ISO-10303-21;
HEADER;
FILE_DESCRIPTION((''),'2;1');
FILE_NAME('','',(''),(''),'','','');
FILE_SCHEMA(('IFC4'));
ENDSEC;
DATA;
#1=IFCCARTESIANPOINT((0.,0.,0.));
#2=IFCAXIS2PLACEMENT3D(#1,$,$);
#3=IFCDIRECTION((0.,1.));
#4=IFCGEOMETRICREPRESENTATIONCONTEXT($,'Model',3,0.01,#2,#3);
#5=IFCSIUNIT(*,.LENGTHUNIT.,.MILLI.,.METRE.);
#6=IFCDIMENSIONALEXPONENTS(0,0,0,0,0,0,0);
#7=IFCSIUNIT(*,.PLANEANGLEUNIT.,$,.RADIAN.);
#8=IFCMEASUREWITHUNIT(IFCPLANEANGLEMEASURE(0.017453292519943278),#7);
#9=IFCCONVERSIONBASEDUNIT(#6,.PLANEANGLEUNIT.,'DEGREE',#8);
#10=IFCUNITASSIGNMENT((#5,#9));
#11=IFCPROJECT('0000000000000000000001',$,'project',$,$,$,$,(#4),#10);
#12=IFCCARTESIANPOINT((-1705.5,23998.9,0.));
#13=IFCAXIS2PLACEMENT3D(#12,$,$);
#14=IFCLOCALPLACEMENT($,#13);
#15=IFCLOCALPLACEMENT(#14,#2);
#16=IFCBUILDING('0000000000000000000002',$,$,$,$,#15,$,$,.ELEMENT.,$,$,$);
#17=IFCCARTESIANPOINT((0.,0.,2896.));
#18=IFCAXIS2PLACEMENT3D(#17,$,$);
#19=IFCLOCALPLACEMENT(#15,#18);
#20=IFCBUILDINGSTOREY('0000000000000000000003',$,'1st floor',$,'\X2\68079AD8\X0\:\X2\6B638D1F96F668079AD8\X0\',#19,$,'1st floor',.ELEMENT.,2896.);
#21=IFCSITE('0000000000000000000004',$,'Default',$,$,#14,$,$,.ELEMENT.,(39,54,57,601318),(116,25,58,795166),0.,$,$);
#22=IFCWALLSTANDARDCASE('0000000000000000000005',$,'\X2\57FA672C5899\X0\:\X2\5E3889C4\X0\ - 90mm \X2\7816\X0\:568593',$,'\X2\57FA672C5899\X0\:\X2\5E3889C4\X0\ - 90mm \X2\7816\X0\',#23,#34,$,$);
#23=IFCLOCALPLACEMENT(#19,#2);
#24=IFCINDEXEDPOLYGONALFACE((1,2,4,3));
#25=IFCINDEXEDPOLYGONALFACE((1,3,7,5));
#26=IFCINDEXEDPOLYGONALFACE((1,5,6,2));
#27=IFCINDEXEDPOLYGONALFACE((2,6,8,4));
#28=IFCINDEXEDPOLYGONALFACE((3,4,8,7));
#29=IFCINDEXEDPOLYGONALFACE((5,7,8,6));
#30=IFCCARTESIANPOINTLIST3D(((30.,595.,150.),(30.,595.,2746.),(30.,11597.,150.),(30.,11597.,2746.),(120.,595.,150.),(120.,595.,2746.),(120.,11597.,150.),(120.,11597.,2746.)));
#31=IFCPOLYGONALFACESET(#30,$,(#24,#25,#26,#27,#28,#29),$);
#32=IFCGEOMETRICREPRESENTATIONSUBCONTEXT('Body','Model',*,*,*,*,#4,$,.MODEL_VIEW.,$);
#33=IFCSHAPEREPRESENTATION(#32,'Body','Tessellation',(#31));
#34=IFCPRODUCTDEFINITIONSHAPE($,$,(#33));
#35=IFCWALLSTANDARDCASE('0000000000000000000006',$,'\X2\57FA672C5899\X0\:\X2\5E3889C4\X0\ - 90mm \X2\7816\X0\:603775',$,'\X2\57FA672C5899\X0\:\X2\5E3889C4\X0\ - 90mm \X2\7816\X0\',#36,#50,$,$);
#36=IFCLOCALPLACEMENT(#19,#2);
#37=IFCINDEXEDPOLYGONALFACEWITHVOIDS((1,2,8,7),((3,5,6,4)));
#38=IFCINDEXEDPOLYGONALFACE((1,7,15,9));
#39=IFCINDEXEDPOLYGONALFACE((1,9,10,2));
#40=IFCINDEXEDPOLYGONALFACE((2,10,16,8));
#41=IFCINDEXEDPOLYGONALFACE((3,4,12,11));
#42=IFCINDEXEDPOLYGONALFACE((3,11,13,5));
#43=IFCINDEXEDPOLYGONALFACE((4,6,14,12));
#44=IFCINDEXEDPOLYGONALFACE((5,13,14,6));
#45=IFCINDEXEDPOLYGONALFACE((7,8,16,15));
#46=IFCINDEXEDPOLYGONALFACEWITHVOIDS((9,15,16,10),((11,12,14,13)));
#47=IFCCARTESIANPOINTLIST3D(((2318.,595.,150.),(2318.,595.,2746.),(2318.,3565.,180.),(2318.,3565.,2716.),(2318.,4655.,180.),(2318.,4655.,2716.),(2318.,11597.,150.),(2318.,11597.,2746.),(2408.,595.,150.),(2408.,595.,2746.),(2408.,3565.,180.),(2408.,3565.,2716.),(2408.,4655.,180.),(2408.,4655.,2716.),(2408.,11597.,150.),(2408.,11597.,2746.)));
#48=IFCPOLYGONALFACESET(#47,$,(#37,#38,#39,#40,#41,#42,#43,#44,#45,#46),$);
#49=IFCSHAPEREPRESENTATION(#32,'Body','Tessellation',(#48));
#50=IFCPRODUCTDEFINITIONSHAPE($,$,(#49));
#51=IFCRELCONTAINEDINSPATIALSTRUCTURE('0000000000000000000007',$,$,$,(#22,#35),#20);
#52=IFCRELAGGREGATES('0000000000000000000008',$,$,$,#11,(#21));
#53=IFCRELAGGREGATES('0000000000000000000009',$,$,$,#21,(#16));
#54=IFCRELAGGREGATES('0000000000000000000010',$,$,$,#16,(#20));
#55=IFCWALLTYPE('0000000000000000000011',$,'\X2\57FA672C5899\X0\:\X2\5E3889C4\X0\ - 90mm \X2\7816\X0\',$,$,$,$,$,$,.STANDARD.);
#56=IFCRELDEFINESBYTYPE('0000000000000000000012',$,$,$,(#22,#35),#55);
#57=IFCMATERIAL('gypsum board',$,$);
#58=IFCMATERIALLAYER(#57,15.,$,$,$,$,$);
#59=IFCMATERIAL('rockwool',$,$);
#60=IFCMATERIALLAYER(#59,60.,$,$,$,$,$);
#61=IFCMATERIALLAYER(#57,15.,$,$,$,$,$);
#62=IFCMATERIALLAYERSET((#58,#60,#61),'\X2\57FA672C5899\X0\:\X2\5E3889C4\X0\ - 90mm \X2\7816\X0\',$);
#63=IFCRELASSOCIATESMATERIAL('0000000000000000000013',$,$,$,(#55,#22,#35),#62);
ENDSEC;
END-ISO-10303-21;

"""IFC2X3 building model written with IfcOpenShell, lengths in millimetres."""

from ifc_helpers import new_model, entity, si_unit, converted_unit, direction, frame, frame_2d, origin, place, context, subcontext, project, spatial, rectangle, extrude, material, layer, layer_set, layer_usage, type_object, element, save


model = new_model("IFC2X3")

# Units and contexts
model_context = context("Model", 3, precision=0.01, world=origin(), true_north=direction((0.0, 1.0)))
body_context = subcontext(model_context, "Body", "Model", "MODEL_VIEW")
ifc_project = project(units=[si_unit("LENGTHUNIT", "METRE", prefix="MILLI"), converted_unit("PLANEANGLEUNIT", "DEGREE", entity("IfcPlaneAngleMeasure", 0.017453292519943278), si_unit("PLANEANGLEUNIT", "RADIAN"), dimensions=[0, 0, 0, 0, 0, 0, 0])], contexts=[model_context])

# Site, building, storey
site_placement = place(None, frame((-1705.5, 23998.9, 0.0)))
site = spatial("IfcSite", under=ifc_project, at=site_placement, Name="Default", CompositionType="ELEMENT", RefLatitude=(39, 54, 57, 601318), RefLongitude=(116, 25, 58, 795166), RefElevation=0.0)
building_placement = place(site_placement, origin())
building = spatial("IfcBuilding", under=site, at=building_placement, CompositionType="ELEMENT")
storey_placement = place(building_placement, frame((0.0, 0.0, 2896.0)))
storey = spatial("IfcBuildingStorey", under=building, at=storey_placement, Name="1st floor", ObjectType="标高:正负零标高", LongName="1st floor", CompositionType="ELEMENT", Elevation=2896.0)

# Wall
ifc_material_1 = material(Name="gypsum board")
ifc_layer_1 = layer(ifc_material_1, 15.0)
ifc_material_2 = material(Name="rockwool")
ifc_layer_2 = layer(ifc_material_2, 60.0)
ifc_layer_3 = layer(ifc_material_1, 15.0)
ifc_layer_set = layer_set([ifc_layer_1, ifc_layer_2, ifc_layer_3], Name="基本墙:常规 - 90mm 砖")
ifc_layer_usage_1 = layer_usage(ifc_layer_set, "AXIS2", "NEGATIVE", 45.0)
wall_type = type_object("IfcWallType", Name="基本墙:常规 - 90mm 砖", PredefinedType="STANDARD", material=ifc_layer_set)
wall_1_placement = place(storey_placement, frame((75.0, 11597.0, 150.0), z_axis=(0.0, 0.0, 1.0), x_axis=(0.0, -1.0, 0.0)))
element("IfcWallStandardCase", 1, at=wall_1_placement, inside=storey, type_object=wall_type, material=ifc_layer_usage_1, Name="基本墙:常规 - 90mm 砖:568593", ObjectType="基本墙:常规 - 90mm 砖", context=body_context, shape_type="SweptSolid", body=[
    extrude(rectangle(XDim=11002.0, YDim=90.0, at=frame_2d((5501.0, 0.0), x_axis=(-1.0, 0.0))), origin(), (0.0, 0.0, 1.0), 2596.0),
])

# Wall, opening
ifc_layer_usage_2 = layer_usage(ifc_layer_set, "AXIS2", "NEGATIVE", 45.0)
wall_2_placement = place(storey_placement, frame((2363.0, 11597.0, 150.0), z_axis=(0.0, 0.0, 1.0), x_axis=(0.0, -1.0, 0.0)))
wall_2 = element("IfcWallStandardCase", 2, at=wall_2_placement, inside=storey, type_object=wall_type, material=ifc_layer_usage_2, Name="基本墙:常规 - 90mm 砖:603775", ObjectType="基本墙:常规 - 90mm 砖", context=body_context, shape_type="SweptSolid", body=[
    extrude(rectangle(XDim=11002.0, YDim=90.0, at=frame_2d((5501.0, 0.0), x_axis=(-1.0, 0.0))), origin(), (0.0, 0.0, 1.0), 2596.0),
])
opening_1_placement = place(wall_2_placement, origin())
element("IfcOpeningElement", 3, at=opening_1_placement, cuts=wall_2, ObjectType="Opening", context=body_context, shape_type="SweptSolid", body=[
    extrude(rectangle(XDim=2536.0, YDim=1090.0, at=frame_2d((0.0, 0.0), x_axis=(0.0, 1.0))), frame((7487.0, 45.0, 1298.0), z_axis=(0.0, -1.0, 0.0), x_axis=(-1.0, 0.0, 0.0)), (0.0, 0.0, 1.0), 90.0),
])

save(model, "model.ifc")
